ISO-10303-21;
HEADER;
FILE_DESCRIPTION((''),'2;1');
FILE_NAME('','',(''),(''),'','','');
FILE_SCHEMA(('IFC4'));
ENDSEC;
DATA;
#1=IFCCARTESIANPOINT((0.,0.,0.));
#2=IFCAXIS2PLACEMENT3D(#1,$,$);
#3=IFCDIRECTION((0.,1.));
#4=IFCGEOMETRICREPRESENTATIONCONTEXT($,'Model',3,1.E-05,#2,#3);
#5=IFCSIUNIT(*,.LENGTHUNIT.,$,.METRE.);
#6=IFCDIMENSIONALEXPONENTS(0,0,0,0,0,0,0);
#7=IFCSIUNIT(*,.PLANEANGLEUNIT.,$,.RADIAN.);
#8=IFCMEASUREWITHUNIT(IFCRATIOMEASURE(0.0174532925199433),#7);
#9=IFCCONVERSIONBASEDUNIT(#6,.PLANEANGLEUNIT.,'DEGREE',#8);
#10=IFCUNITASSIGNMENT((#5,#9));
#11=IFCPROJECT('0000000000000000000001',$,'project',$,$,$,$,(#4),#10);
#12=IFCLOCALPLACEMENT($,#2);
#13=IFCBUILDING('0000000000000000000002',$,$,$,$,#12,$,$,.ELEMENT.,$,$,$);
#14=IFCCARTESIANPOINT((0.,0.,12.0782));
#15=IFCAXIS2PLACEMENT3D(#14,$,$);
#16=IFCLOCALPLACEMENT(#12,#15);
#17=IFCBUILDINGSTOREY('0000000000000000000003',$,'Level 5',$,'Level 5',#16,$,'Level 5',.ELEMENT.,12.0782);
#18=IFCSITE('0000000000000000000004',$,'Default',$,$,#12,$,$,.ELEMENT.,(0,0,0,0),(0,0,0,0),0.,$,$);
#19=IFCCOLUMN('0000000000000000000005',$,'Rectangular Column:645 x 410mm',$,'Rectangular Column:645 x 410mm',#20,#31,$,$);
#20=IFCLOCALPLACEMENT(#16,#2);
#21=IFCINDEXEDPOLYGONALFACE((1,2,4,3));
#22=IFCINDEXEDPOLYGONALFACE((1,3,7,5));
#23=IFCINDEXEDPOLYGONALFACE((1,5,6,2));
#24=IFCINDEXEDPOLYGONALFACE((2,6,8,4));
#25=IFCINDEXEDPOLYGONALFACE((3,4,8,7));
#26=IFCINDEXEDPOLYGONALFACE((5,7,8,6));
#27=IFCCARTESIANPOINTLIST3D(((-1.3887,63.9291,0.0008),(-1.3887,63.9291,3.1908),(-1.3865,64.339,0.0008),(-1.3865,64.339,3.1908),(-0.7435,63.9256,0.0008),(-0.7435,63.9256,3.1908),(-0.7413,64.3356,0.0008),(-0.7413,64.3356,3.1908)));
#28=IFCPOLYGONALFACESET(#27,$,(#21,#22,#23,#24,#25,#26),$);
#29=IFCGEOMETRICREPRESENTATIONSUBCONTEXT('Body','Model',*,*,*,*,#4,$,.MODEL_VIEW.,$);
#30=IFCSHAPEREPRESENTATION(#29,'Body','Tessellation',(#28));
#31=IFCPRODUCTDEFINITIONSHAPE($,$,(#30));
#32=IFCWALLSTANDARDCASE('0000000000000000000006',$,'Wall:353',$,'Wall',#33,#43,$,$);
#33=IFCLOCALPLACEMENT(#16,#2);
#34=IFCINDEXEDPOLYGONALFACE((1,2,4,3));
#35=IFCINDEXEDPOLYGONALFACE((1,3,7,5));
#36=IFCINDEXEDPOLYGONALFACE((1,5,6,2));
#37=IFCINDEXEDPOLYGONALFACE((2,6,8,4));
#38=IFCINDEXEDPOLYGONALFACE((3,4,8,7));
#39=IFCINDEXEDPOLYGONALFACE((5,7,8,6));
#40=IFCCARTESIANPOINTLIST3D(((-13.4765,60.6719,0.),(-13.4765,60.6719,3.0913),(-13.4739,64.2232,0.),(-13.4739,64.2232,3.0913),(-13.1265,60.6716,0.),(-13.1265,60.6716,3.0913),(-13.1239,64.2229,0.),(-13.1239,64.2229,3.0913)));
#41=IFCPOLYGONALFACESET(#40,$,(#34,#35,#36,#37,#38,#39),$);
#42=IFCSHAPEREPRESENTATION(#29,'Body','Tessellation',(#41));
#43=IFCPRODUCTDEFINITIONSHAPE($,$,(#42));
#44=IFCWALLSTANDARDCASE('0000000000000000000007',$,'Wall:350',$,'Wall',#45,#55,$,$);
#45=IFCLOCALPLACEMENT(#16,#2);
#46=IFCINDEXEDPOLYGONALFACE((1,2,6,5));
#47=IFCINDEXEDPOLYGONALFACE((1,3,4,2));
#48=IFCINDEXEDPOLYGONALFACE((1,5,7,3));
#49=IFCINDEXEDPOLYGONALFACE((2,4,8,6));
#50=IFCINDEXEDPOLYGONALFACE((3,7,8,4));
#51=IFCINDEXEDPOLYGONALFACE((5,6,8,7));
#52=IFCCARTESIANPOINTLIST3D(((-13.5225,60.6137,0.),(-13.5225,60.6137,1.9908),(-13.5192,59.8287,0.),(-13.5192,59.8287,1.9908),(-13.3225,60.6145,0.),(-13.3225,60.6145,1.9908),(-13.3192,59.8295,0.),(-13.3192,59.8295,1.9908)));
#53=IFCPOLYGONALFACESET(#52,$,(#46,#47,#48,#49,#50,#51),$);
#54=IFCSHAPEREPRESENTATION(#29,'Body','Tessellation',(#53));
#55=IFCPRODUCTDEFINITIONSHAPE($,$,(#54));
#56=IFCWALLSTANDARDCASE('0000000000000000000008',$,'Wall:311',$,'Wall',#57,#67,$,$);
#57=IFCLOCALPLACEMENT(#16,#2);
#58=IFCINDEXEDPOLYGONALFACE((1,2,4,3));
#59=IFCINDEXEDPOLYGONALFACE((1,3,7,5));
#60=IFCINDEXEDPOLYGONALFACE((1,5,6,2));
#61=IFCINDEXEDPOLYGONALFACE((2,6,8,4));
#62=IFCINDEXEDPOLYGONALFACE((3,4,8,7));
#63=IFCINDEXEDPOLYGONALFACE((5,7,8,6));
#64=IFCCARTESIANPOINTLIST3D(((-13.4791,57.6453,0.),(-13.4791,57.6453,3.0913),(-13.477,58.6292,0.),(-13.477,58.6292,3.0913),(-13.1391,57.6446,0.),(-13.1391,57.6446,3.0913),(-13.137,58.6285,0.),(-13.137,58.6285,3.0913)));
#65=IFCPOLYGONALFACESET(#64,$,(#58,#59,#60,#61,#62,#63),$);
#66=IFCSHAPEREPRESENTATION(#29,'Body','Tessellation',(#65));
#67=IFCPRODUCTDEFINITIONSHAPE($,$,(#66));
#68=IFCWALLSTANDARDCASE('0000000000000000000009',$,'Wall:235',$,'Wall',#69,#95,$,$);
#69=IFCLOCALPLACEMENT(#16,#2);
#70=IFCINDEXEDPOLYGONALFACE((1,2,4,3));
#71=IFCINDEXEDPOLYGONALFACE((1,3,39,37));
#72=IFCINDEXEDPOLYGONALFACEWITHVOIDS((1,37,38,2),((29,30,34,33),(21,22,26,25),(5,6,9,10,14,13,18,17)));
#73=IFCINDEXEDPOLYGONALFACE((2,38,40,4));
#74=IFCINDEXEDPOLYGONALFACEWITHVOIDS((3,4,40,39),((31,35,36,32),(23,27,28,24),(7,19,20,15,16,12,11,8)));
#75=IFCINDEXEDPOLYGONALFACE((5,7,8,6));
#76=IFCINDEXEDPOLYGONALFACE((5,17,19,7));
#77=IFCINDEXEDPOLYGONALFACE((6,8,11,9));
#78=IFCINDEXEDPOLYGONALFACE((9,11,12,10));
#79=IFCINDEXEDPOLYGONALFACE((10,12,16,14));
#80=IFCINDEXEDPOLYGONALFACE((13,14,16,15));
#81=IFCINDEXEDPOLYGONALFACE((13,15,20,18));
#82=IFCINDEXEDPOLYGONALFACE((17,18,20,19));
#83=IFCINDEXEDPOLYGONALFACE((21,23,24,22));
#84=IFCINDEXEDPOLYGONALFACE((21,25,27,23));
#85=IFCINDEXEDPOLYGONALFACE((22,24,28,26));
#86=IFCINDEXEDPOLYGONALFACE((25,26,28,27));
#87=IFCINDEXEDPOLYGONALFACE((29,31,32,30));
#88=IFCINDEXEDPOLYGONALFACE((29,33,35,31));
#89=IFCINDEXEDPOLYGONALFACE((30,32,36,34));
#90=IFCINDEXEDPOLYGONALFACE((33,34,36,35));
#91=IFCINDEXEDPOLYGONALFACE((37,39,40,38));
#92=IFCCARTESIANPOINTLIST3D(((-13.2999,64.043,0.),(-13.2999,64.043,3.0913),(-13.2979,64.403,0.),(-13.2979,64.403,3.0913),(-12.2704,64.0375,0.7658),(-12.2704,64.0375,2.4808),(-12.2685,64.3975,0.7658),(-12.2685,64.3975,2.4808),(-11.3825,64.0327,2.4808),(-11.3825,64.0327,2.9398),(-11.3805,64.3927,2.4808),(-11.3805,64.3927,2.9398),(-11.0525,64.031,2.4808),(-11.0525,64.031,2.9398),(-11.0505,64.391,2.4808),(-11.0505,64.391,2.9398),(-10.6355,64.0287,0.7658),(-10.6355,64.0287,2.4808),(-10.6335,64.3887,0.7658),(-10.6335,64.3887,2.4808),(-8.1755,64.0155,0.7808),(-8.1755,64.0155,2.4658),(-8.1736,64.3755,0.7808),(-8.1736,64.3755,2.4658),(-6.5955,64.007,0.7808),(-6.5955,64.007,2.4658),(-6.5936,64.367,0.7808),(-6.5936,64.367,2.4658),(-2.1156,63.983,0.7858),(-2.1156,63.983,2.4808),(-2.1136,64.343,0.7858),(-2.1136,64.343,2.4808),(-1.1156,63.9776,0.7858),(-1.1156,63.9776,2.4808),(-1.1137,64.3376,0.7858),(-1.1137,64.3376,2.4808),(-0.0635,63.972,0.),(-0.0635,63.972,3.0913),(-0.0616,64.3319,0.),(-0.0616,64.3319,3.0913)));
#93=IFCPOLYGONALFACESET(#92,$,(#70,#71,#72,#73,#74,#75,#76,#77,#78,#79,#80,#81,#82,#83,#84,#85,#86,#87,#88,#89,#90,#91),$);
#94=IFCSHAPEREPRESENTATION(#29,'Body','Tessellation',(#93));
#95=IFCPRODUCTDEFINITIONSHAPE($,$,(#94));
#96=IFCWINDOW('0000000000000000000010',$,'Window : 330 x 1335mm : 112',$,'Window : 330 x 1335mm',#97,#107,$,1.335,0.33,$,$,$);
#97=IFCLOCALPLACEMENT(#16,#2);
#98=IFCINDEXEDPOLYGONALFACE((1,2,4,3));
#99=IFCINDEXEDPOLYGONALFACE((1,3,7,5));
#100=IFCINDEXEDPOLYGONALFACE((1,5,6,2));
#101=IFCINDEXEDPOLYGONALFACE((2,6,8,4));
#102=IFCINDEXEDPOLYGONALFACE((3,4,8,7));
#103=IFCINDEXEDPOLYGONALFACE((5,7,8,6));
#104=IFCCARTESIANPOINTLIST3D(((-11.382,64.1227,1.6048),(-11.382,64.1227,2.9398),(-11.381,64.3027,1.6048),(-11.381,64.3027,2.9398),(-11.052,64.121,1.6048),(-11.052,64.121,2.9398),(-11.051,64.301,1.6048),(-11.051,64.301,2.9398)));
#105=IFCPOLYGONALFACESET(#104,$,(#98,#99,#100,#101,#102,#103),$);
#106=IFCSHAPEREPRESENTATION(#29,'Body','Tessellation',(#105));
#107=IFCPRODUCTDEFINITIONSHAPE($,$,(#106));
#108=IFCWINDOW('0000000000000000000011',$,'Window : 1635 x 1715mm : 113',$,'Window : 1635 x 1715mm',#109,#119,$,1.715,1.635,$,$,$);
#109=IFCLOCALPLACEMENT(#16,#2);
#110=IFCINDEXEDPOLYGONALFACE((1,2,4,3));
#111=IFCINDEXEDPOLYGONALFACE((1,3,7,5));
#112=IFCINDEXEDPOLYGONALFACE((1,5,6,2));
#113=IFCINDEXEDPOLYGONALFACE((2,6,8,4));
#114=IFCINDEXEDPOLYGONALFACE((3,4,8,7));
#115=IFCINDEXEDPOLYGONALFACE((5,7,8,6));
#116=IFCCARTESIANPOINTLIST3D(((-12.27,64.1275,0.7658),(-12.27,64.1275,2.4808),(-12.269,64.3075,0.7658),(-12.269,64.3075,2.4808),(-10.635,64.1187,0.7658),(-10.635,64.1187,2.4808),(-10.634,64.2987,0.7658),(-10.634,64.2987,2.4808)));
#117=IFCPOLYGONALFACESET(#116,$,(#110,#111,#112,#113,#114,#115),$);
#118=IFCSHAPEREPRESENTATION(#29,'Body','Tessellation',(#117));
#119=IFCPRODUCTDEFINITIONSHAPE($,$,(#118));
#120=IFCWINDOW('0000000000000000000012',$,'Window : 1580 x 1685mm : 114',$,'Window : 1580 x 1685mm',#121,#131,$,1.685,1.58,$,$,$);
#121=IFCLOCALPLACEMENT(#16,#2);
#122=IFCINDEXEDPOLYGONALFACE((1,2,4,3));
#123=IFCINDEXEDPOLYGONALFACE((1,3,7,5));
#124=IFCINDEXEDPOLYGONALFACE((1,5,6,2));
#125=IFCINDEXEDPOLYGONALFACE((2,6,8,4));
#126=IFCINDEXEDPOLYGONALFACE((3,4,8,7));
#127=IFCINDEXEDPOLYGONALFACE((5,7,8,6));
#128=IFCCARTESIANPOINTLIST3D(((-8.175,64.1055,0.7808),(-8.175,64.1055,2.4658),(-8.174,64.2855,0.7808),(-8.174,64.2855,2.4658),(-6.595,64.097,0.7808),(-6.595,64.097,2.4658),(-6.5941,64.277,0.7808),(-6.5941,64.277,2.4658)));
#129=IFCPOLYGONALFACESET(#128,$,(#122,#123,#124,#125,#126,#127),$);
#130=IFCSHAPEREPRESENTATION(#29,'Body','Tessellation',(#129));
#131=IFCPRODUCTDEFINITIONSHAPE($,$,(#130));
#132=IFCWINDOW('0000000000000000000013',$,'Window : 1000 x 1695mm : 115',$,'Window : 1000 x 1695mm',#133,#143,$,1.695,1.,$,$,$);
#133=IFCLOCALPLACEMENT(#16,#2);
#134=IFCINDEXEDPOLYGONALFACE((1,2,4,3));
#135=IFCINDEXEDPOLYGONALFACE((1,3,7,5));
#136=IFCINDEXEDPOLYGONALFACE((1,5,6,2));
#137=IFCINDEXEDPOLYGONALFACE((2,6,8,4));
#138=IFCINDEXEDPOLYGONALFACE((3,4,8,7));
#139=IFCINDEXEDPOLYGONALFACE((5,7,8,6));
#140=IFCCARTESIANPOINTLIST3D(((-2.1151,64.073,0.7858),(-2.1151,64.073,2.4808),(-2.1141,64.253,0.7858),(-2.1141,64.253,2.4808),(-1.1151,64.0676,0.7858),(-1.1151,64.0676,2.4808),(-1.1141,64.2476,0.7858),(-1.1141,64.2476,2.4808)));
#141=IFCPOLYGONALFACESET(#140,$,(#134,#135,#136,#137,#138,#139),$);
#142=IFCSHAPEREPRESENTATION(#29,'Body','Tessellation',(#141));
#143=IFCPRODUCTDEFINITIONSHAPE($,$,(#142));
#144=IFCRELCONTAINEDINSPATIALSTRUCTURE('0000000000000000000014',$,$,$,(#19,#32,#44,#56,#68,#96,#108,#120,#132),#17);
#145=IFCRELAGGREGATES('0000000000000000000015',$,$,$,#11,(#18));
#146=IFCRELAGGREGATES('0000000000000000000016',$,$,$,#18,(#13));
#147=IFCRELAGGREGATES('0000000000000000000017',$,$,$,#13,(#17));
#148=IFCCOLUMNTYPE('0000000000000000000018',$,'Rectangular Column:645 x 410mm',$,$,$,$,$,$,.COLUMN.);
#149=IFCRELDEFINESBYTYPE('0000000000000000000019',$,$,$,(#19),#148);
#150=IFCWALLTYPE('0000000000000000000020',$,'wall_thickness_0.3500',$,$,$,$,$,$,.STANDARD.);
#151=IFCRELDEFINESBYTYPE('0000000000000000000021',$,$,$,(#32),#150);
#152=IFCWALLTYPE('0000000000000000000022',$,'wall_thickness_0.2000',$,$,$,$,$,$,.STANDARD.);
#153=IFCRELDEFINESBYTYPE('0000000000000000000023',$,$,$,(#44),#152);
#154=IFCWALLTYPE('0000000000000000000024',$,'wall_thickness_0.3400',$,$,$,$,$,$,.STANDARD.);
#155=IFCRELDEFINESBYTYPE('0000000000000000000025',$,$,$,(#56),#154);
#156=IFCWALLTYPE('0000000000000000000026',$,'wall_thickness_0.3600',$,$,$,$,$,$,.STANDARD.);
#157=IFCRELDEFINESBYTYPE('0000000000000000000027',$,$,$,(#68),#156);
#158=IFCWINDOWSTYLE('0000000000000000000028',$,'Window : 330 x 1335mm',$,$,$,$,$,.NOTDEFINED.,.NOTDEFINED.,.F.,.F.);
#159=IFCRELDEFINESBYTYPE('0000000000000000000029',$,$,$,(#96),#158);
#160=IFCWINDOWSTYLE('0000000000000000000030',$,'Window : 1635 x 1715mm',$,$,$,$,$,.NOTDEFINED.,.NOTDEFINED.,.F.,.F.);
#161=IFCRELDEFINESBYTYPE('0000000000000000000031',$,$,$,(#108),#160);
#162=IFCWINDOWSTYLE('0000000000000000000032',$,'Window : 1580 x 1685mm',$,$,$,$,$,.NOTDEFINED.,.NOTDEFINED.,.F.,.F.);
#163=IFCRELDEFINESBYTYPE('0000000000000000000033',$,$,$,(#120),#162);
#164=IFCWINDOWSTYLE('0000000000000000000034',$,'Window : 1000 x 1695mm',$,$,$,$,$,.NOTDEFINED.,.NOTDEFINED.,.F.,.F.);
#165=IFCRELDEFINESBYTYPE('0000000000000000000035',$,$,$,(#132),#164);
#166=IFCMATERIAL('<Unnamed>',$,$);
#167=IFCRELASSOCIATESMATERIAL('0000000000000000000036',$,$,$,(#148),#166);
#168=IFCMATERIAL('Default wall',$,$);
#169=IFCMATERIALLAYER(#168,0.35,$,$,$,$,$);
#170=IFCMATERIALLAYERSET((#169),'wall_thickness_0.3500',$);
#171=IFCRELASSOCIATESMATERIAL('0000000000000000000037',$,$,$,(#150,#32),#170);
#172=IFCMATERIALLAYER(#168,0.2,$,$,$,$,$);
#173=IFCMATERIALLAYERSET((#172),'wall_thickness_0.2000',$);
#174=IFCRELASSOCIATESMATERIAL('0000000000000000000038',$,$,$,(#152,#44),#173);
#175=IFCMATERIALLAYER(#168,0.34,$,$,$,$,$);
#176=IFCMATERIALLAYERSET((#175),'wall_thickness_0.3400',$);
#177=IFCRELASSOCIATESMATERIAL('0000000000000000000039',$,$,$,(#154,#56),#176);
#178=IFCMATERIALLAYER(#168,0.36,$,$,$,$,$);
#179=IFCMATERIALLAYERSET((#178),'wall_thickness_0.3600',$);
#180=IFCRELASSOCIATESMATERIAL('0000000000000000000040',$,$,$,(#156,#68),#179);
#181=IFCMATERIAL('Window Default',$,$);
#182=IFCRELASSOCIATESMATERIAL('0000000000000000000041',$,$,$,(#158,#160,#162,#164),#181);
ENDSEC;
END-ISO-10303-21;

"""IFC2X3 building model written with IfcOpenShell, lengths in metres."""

from ifc_helpers import new_model, entity, si_unit, converted_unit, direction, frame, frame_2d, origin, origin_2d_with_axis, place, context, subcontext, project, spatial, polyline, rectangle, outline, extrude, clip, halfspace, source, transform, mapped, material, layer, layer_set, layer_usage, type_object, type_shapes, element, fill, save


model = new_model("IFC2X3")

# Units and contexts
model_context = context("Model", 3, precision=1e-05, world=origin(), true_north=direction((0.0, 1.0)))
body_context = subcontext(model_context, "Body", "Model", "MODEL_VIEW")
ifc_project = project(units=[si_unit("LENGTHUNIT", "METRE"), converted_unit("PLANEANGLEUNIT", "DEGREE", entity("IfcRatioMeasure", 0.0174532925199433), si_unit("PLANEANGLEUNIT", "RADIAN"), dimensions=[0, 0, 0, 0, 0, 0, 0])], contexts=[model_context])

# Site, building, storey
placement_1 = place(None, origin())
site = spatial("IfcSite", under=ifc_project, at=placement_1, Name="Default", CompositionType="ELEMENT", RefLatitude=(0, 0, 0, 0), RefLongitude=(0, 0, 0, 0), RefElevation=0.0)
building = spatial("IfcBuilding", under=site, at=placement_1, CompositionType="ELEMENT")
storey_placement = place(placement_1, frame((0.0, 0.0, 12.0782)))
storey = spatial("IfcBuildingStorey", under=building, at=storey_placement, Name="Level 5", ObjectType="Level 5", LongName="Level 5", CompositionType="ELEMENT", Elevation=12.0782)

# Column
ifc_material_1 = material(Name="<Unnamed>")
column_type = type_object("IfcColumnType", Name="Rectangular Column:645 x 410mm", PredefinedType="COLUMN", material=ifc_material_1)
shared_shape_1 = source(origin(), body_context, "Body", "SweptSolid", [
    extrude(rectangle(XDim=0.6452, YDim=0.41, at=origin_2d_with_axis()), frame((0.0, 0.0, 0.0), z_axis=(0.0, 0.0, 1.0), x_axis=(0.0, -1.0, 0.0)), (0.0, 0.0, 1.0), 3.19),
])
type_shapes(column_type, [shared_shape_1])
column_placement = place(placement_1, frame((-1.065, 64.1323, 12.079), z_axis=(0.0, 0.0, 1.0), x_axis=(0.00539, 0.999985, 0.0)))
element("IfcColumn", 1, at=column_placement, inside=storey, type_object=column_type, Name="Rectangular Column:645 x 410mm", ObjectType="Rectangular Column:645 x 410mm", context=body_context, shape_type="MappedRepresentation", body=[
    mapped(shared_shape_1, transform((0.0, 0.0, 0.0), scale=1.0)),
])

# Walls
ifc_material_2 = material(Name="Default wall")
ifc_layer_1 = layer(ifc_material_2, 0.35)
ifc_layer_set_1 = layer_set([ifc_layer_1], Name="wall_thickness_0.3500")
ifc_layer_usage_1 = layer_usage(ifc_layer_set_1, "AXIS2", "POSITIVE", -0.175)
wall_type_1 = type_object("IfcWallType", Name="wall_thickness_0.3500", PredefinedType="STANDARD", material=ifc_layer_set_1)
wall_1_placement = place(storey_placement, frame((-13.2989, 64.223, 0.0), z_axis=(0.0, 0.0, 1.0), x_axis=(-0.000727, -1.0, 0.0)))
element("IfcWallStandardCase", 2, at=wall_1_placement, inside=storey, type_object=wall_type_1, material=ifc_layer_usage_1, Name="Wall:353", ObjectType="Wall", context=body_context, shape_type="SweptSolid", body=[
    extrude(outline(polyline([(3.5513, -0.175), (3.5513, 0.175), (0.0, 0.175), (0.0, -0.175), (3.5513, -0.175)])), origin(), (0.0, 0.0, 1.0), 3.0913),
])
ifc_layer_2 = layer(ifc_material_2, 0.2)
ifc_layer_set_2 = layer_set([ifc_layer_2], Name="wall_thickness_0.2000")
ifc_layer_usage_2 = layer_usage(ifc_layer_set_2, "AXIS2", "POSITIVE", -0.1)
wall_type_2 = type_object("IfcWallType", Name="wall_thickness_0.2000", PredefinedType="STANDARD", material=ifc_layer_set_2)
wall_2_placement = place(storey_placement, frame((-13.4192, 59.8291, 0.0), z_axis=(0.0, 0.0, 1.0), x_axis=(-0.004239, 0.999991, 0.0)))
element("IfcWallStandardCase", 3, at=wall_2_placement, inside=storey, type_object=wall_type_2, material=ifc_layer_usage_2, Name="Wall:350", ObjectType="Wall", context=body_context, shape_type="SweptSolid", body=[
    extrude(outline(polyline([(0.785, -0.1), (0.785, 0.1), (0.0, 0.1), (0.0, -0.1), (0.785, -0.1)])), origin(), (0.0, 0.0, 1.0), 1.9908),
])
ifc_layer_3 = layer(ifc_material_2, 0.34)
ifc_layer_set_3 = layer_set([ifc_layer_3], Name="wall_thickness_0.3400")
ifc_layer_usage_3 = layer_usage(ifc_layer_set_3, "AXIS2", "POSITIVE", -0.17)
wall_type_3 = type_object("IfcWallType", Name="wall_thickness_0.3400", PredefinedType="STANDARD", material=ifc_layer_set_3)
wall_3_placement = place(storey_placement, frame((-13.307, 58.6288, 0.0), z_axis=(0.0, 0.0, 1.0), x_axis=(-0.002111, -0.999998, 0.0)))
element("IfcWallStandardCase", 4, at=wall_3_placement, inside=storey, type_object=wall_type_3, material=ifc_layer_usage_3, Name="Wall:311", ObjectType="Wall", context=body_context, shape_type="SweptSolid", body=[
    extrude(outline(polyline([(0.9839, -0.17), (0.9839, 0.17), (0.0, 0.17), (0.0, -0.17), (0.9839, -0.17)])), origin(), (0.0, 0.0, 1.0), 3.0913),
])

# Wall, openings, windows
ifc_layer_4 = layer(ifc_material_2, 0.36)
ifc_layer_set_4 = layer_set([ifc_layer_4], Name="wall_thickness_0.3600")
ifc_layer_usage_4 = layer_usage(ifc_layer_set_4, "AXIS2", "POSITIVE", -0.18)
wall_type_4 = type_object("IfcWallType", Name="wall_thickness_0.3600", PredefinedType="STANDARD", material=ifc_layer_set_4)
wall_4_placement = place(storey_placement, frame((-13.2989, 64.223, 0.0), z_axis=(0.0, 0.0, 1.0), x_axis=(0.999986, -0.00537, 0.0)))
wall_4 = element("IfcWallStandardCase", 5, at=wall_4_placement, inside=storey, type_object=wall_type_4, material=ifc_layer_usage_4, Name="Wall:235", ObjectType="Wall", context=body_context, shape_type="Clipping", body=[
    clip(extrude(outline(polyline([(13.2366, -0.18), (13.2366, 0.18), (0.0, 0.18), (0.0, -0.18), (13.2366, -0.18)])), origin(), (0.0, 0.0, 1.0), 3.0913), halfspace(frame((37.9612, -6.5167, 9.0135), z_axis=(0.000382, 0.389455, 0.921045), x_axis=(-0.999996, 0.00278, -0.000761)), False)),
])
opening_1_placement = place(wall_4_placement, frame((1.9174, -0.18, 1.6048)))
opening_1 = element("IfcOpeningElement", 6, at=opening_1_placement, cuts=wall_4, ObjectType="Opening", context=body_context, shape_type="SweptSolid", body=[
    extrude(rectangle(XDim=0.33, YDim=1.335, at=frame_2d((0.6675, 0.165), x_axis=(0.0, 1.0))), frame((0.0, 0.0, 0.0), z_axis=(0.0, 1.0, 0.0), x_axis=(0.0, 0.0, 1.0)), (0.0, 0.0, 1.0), 0.36),
])
opening_2_placement = place(wall_4_placement, frame((1.0294, -0.18, 0.7658)))
opening_2 = element("IfcOpeningElement", 7, at=opening_2_placement, cuts=wall_4, ObjectType="Opening", context=body_context, shape_type="SweptSolid", body=[
    extrude(rectangle(XDim=1.635, YDim=1.715, at=frame_2d((0.8575, 0.8175), x_axis=(0.0, 1.0))), frame((0.0, 0.0, 0.0), z_axis=(0.0, 1.0, 0.0), x_axis=(0.0, 0.0, 1.0)), (0.0, 0.0, 1.0), 0.36),
])
opening_3_placement = place(wall_4_placement, frame((5.1244, -0.18, 0.7808)))
opening_3 = element("IfcOpeningElement", 8, at=opening_3_placement, cuts=wall_4, ObjectType="Opening", context=body_context, shape_type="SweptSolid", body=[
    extrude(rectangle(XDim=1.58, YDim=1.685, at=frame_2d((0.8425, 0.79), x_axis=(0.0, 1.0))), frame((0.0, 0.0, 0.0), z_axis=(0.0, 1.0, 0.0), x_axis=(0.0, 0.0, 1.0)), (0.0, 0.0, 1.0), 0.36),
])
opening_4_placement = place(wall_4_placement, frame((11.1844, -0.18, 0.7858)))
opening_4 = element("IfcOpeningElement", 9, at=opening_4_placement, cuts=wall_4, ObjectType="Opening", context=body_context, shape_type="SweptSolid", body=[
    extrude(rectangle(XDim=1.0, YDim=1.695, at=frame_2d((0.8475, 0.5), x_axis=(0.0, 1.0))), frame((0.0, 0.0, 0.0), z_axis=(0.0, 1.0, 0.0), x_axis=(0.0, 0.0, 1.0)), (0.0, 0.0, 1.0), 0.36),
])
ifc_material_3 = material(Name="Window Default")
window_style_1 = type_object("IfcWindowStyle", Name="Window : 330 x 1335mm", ConstructionType="NOTDEFINED", OperationType="NOTDEFINED", ParameterTakesPrecedence=False, Sizeable=False, material=ifc_material_3)
shared_shape_2 = source(origin(), body_context, "Body", "SweptSolid", [
    extrude(rectangle(XDim=0.18, YDim=0.33, at=origin_2d_with_axis()), frame((0.165, 0.18, 0.0), z_axis=(0.0, 0.0, 1.0), x_axis=(0.0, 1.0, 0.0)), (0.0, 0.0, 1.0), 1.335),
])
type_shapes(window_style_1, [shared_shape_2])
window_1_placement = place(opening_1_placement, origin())
window_1 = element("IfcWindow", 10, at=window_1_placement, inside=storey, type_object=window_style_1, Name="Window : 330 x 1335mm : 112", ObjectType="Window : 330 x 1335mm", OverallHeight=1.335, OverallWidth=0.33, context=body_context, shape_type="MappedRepresentation", body=[
    mapped(shared_shape_2, transform((0.0, 0.0, 0.0), scale=1.0)),
])
fill(opening_1, window_1)
window_style_2 = type_object("IfcWindowStyle", Name="Window : 1635 x 1715mm", ConstructionType="NOTDEFINED", OperationType="NOTDEFINED", ParameterTakesPrecedence=False, Sizeable=False, material=ifc_material_3)
shared_shape_3 = source(origin(), body_context, "Body", "SweptSolid", [
    extrude(rectangle(XDim=0.18, YDim=1.635, at=origin_2d_with_axis()), frame((0.8175, 0.18, 0.0), z_axis=(0.0, 0.0, 1.0), x_axis=(0.0, 1.0, 0.0)), (0.0, 0.0, 1.0), 1.715),
])
type_shapes(window_style_2, [shared_shape_3])
window_2_placement = place(opening_2_placement, origin())
window_2 = element("IfcWindow", 11, at=window_2_placement, inside=storey, type_object=window_style_2, Name="Window : 1635 x 1715mm : 113", ObjectType="Window : 1635 x 1715mm", OverallHeight=1.715, OverallWidth=1.635, context=body_context, shape_type="MappedRepresentation", body=[
    mapped(shared_shape_3, transform((0.0, 0.0, 0.0), scale=1.0)),
])
fill(opening_2, window_2)
window_style_3 = type_object("IfcWindowStyle", Name="Window : 1580 x 1685mm", ConstructionType="NOTDEFINED", OperationType="NOTDEFINED", ParameterTakesPrecedence=False, Sizeable=False, material=ifc_material_3)
shared_shape_4 = source(origin(), body_context, "Body", "SweptSolid", [
    extrude(rectangle(XDim=0.18, YDim=1.58, at=origin_2d_with_axis()), frame((0.79, 0.18, 0.0), z_axis=(0.0, 0.0, 1.0), x_axis=(0.0, 1.0, 0.0)), (0.0, 0.0, 1.0), 1.685),
])
type_shapes(window_style_3, [shared_shape_4])
window_3_placement = place(opening_3_placement, origin())
window_3 = element("IfcWindow", 12, at=window_3_placement, inside=storey, type_object=window_style_3, Name="Window : 1580 x 1685mm : 114", ObjectType="Window : 1580 x 1685mm", OverallHeight=1.685, OverallWidth=1.58, context=body_context, shape_type="MappedRepresentation", body=[
    mapped(shared_shape_4, transform((0.0, 0.0, 0.0), scale=1.0)),
])
fill(opening_3, window_3)
window_style_4 = type_object("IfcWindowStyle", Name="Window : 1000 x 1695mm", ConstructionType="NOTDEFINED", OperationType="NOTDEFINED", ParameterTakesPrecedence=False, Sizeable=False, material=ifc_material_3)
shared_shape_5 = source(origin(), body_context, "Body", "SweptSolid", [
    extrude(rectangle(XDim=0.18, YDim=1.0, at=origin_2d_with_axis()), frame((0.5, 0.18, 0.0), z_axis=(0.0, 0.0, 1.0), x_axis=(0.0, 1.0, 0.0)), (0.0, 0.0, 1.0), 1.695),
])
type_shapes(window_style_4, [shared_shape_5])
window_4_placement = place(opening_4_placement, origin())
window_4 = element("IfcWindow", 13, at=window_4_placement, inside=storey, type_object=window_style_4, Name="Window : 1000 x 1695mm : 115", ObjectType="Window : 1000 x 1695mm", OverallHeight=1.695, OverallWidth=1.0, context=body_context, shape_type="MappedRepresentation", body=[
    mapped(shared_shape_5, transform((0.0, 0.0, 0.0), scale=1.0)),
])
fill(opening_4, window_4)

save(model, "model.ifc")
